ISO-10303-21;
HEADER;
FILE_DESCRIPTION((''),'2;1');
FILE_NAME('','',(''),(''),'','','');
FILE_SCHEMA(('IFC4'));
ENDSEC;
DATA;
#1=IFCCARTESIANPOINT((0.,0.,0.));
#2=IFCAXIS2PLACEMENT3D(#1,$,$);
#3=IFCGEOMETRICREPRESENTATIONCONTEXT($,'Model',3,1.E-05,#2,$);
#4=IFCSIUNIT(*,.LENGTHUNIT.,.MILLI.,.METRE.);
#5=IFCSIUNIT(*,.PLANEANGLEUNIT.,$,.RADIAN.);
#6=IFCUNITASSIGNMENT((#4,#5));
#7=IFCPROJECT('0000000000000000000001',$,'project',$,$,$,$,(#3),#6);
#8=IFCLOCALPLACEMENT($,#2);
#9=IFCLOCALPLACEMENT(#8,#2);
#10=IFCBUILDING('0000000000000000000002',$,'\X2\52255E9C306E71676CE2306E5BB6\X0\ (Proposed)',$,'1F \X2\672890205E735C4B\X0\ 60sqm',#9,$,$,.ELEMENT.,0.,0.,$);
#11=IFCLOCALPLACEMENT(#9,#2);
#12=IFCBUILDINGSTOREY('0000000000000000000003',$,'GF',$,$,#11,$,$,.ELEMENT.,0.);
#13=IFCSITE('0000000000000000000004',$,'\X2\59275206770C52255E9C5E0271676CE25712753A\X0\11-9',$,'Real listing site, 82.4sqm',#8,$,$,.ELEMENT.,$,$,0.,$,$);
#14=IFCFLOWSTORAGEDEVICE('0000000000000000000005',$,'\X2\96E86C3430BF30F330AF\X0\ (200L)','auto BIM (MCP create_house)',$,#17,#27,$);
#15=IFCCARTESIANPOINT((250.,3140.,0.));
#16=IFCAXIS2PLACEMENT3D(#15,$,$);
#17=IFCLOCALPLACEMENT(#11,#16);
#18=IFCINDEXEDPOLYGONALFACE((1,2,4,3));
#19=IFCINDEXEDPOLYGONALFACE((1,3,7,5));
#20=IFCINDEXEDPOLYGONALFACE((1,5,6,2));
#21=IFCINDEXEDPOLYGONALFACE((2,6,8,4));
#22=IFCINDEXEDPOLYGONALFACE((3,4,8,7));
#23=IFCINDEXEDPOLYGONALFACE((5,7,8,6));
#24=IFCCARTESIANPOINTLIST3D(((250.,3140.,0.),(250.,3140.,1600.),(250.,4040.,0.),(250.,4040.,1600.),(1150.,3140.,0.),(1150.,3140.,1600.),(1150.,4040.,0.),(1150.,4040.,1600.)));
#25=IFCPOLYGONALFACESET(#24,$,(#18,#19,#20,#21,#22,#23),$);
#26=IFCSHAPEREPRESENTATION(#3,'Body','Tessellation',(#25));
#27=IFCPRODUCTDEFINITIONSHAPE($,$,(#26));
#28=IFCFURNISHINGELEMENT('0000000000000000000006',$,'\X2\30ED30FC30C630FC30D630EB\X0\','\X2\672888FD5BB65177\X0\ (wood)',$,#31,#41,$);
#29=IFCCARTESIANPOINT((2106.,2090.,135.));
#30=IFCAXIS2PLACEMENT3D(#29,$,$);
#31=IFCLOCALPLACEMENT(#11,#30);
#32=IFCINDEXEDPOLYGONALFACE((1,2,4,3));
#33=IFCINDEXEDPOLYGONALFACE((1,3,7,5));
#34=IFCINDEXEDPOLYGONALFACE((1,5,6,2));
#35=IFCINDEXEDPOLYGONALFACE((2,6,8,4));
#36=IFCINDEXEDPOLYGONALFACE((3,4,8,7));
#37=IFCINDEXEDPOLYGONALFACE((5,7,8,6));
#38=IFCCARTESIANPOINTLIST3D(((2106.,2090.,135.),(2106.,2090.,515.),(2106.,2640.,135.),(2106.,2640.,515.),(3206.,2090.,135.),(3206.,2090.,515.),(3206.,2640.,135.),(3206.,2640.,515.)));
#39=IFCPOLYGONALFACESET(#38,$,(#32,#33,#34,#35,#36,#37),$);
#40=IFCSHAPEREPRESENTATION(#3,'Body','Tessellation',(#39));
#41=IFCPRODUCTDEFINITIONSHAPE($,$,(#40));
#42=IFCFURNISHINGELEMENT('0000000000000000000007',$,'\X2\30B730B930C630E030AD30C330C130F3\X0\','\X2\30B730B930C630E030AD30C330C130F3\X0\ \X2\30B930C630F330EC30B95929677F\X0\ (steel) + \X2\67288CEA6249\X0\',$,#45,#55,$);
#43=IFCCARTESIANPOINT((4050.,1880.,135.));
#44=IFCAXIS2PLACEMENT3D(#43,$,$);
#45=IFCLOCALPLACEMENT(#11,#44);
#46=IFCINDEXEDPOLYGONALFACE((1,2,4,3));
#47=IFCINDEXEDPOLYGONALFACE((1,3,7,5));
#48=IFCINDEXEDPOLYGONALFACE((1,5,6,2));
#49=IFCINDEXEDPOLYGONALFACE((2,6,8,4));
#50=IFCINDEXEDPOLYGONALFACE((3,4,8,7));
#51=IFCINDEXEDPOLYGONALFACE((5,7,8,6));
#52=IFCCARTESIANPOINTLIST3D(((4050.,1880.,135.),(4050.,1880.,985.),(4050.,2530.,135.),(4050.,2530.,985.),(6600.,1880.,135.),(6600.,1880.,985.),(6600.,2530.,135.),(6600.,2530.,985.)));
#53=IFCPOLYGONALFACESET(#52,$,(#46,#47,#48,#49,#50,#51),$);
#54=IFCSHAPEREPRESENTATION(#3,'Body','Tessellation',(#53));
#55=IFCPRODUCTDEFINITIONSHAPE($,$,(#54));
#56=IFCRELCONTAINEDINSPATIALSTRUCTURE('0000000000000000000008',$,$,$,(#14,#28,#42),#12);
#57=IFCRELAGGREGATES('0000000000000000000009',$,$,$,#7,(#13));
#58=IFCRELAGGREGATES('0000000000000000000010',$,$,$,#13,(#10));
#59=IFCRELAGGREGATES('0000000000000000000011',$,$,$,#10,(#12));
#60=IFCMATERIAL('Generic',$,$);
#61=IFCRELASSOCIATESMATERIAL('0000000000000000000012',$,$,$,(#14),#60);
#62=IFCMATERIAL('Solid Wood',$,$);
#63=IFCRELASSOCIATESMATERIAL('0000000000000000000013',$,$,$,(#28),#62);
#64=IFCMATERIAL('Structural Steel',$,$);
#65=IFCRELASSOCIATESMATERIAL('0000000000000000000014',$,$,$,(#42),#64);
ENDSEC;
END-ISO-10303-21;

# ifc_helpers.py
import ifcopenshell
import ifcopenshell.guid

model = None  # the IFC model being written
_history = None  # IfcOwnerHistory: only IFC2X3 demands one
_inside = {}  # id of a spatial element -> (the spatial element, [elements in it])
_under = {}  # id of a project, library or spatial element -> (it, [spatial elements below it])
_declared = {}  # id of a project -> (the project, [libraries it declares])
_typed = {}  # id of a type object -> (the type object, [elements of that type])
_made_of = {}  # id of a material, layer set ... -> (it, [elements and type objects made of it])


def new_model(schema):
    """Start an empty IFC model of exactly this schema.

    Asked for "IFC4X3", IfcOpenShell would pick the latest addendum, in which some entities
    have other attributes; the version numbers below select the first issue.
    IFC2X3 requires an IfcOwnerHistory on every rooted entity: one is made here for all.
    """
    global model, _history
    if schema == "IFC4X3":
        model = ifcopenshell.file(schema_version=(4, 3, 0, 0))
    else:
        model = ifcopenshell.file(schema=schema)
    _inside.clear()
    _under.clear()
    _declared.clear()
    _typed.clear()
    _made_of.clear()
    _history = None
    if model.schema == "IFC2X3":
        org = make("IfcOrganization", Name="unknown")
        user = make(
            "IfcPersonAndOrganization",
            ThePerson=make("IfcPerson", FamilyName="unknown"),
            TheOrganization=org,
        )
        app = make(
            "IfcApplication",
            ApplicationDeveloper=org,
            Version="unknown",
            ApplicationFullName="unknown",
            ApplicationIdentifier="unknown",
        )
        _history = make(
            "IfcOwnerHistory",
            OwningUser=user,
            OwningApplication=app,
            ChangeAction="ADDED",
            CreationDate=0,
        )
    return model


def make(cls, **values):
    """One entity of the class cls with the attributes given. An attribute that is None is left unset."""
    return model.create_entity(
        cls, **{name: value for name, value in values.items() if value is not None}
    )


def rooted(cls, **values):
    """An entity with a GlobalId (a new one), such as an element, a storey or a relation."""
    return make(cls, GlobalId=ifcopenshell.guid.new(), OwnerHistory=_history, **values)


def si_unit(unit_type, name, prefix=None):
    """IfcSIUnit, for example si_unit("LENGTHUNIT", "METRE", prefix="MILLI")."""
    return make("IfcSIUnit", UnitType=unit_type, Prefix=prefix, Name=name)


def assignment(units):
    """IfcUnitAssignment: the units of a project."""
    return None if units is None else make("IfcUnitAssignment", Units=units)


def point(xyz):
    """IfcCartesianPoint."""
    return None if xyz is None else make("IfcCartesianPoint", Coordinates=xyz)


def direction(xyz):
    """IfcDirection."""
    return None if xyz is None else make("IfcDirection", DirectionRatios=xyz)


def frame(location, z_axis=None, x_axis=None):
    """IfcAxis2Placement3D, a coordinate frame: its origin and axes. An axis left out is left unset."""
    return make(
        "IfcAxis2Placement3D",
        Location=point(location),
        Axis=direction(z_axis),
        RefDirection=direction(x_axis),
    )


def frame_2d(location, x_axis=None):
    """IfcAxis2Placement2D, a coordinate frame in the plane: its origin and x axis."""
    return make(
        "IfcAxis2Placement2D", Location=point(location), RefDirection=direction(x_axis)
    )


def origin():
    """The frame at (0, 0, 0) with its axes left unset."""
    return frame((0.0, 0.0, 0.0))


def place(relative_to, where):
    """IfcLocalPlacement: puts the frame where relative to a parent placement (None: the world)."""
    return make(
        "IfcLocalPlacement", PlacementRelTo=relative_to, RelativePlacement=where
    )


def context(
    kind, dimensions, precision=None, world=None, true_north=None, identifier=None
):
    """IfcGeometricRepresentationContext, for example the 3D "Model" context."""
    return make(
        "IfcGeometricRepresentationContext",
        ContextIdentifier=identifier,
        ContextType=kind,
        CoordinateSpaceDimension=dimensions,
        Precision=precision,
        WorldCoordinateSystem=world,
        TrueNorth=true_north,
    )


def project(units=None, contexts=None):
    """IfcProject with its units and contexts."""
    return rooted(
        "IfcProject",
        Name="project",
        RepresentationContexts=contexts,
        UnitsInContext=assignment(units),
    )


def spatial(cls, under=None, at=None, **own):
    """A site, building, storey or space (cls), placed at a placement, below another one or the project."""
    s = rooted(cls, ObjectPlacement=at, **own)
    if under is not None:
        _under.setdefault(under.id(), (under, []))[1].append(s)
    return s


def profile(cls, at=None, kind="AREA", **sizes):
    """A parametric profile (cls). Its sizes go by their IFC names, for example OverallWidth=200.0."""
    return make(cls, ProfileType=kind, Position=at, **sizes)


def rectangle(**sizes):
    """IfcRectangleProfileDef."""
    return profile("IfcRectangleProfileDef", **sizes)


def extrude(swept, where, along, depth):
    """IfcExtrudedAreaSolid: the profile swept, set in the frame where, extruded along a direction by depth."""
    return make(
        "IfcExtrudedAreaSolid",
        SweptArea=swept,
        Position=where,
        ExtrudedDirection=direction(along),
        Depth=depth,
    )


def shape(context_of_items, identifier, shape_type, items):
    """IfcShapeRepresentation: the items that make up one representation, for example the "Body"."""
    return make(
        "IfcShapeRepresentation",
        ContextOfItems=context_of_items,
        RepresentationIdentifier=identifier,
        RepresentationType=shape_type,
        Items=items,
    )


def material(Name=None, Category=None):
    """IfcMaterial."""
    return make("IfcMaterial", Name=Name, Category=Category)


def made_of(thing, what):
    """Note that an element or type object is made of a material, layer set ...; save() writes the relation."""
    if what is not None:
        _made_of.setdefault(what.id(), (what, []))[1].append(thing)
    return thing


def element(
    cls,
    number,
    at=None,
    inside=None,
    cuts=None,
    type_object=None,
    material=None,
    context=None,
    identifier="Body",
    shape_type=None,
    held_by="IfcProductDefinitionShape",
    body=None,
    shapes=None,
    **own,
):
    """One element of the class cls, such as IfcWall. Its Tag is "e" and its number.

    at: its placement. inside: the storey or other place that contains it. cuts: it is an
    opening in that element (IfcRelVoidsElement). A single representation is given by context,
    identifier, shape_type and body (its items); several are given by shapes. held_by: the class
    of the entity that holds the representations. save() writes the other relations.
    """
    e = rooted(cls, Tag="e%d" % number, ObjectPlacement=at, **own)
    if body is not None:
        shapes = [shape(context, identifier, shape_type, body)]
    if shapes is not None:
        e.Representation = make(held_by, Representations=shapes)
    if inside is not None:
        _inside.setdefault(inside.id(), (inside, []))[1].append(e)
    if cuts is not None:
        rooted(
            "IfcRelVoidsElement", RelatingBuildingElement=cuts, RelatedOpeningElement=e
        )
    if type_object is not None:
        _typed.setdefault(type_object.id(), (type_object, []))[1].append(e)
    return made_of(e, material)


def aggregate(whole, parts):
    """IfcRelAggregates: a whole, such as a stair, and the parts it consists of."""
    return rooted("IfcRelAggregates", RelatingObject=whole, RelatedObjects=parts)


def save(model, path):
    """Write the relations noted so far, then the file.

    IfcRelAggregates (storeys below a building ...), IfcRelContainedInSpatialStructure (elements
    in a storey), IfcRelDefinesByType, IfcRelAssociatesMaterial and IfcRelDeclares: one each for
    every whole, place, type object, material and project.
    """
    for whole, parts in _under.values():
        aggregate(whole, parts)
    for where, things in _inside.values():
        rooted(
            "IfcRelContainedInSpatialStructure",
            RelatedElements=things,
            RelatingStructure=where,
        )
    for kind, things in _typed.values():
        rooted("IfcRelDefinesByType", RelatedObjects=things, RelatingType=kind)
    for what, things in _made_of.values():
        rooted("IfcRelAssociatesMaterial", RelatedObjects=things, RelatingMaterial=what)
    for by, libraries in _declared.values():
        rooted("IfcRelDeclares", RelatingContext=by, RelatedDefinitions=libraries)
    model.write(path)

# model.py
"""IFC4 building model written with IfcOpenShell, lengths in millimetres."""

from ifc_helpers import new_model, si_unit, frame, frame_2d, origin, place, context, project, spatial, rectangle, extrude, material, element, save


model = new_model("IFC4")

# Units and contexts
model_context = context("Model", 3, precision=1e-05, world=origin())
ifc_project = project(units=[si_unit("LENGTHUNIT", "METRE", prefix="MILLI"), si_unit("PLANEANGLEUNIT", "RADIAN")], contexts=[model_context])

# Site, building, storey
site_placement = place(None, origin())
site = spatial("IfcSite", under=ifc_project, at=site_placement, Name="大分県別府市照波園町11-9", ObjectType="Real listing site, 82.4sqm", CompositionType="ELEMENT", RefElevation=0.0)
building_placement = place(site_placement, origin())
building = spatial("IfcBuilding", under=site, at=building_placement, Name="別府の照波の家 (Proposed)", ObjectType="1F 木造平屋 60sqm", CompositionType="ELEMENT", ElevationOfRefHeight=0.0, ElevationOfTerrain=0.0)
storey_placement = place(building_placement, origin())
storey = spatial("IfcBuildingStorey", under=building, at=storey_placement, Name="GF", CompositionType="ELEMENT", Elevation=0.0)

# Shared definitions
ifc_material_1 = material(Name="Solid Wood")

# Shared definitions
ifc_material_2 = material(Name="Generic")

# Flow storage device
flow_storage_device_placement = place(storey_placement, frame((250.0, 3140.0, 0.0)))
element("IfcFlowStorageDevice", 1, at=flow_storage_device_placement, inside=storey, material=ifc_material_2, Name="雨水タンク (200L)", Description="auto BIM (MCP create_house)", context=model_context, shape_type="SweptSolid", body=[
    extrude(rectangle(XDim=900.0, YDim=900.0, at=frame_2d((450.0, 450.0))), frame((250.0, 3140.0, 0.0)), (0.0, 0.0, 1.0), 1600.0),
])

# Furnishing elements
furnishing_1_placement = place(storey_placement, frame((2106.0, 2090.0, 135.0)))
element("IfcFurnishingElement", 2, at=furnishing_1_placement, inside=storey, material=ifc_material_1, Name="ローテーブル", Description="木製家具 (wood)", context=model_context, shape_type="SweptSolid", body=[
    extrude(rectangle(XDim=1100.0, YDim=550.0, at=frame_2d((550.0, 275.0))), frame((2106.0, 2090.0, 135.0)), (0.0, 0.0, 1.0), 380.0),
])
ifc_material_3 = material(Name="Structural Steel")
furnishing_2_placement = place(storey_placement, frame((4050.0, 1880.0, 135.0)))
element("IfcFurnishingElement", 3, at=furnishing_2_placement, inside=storey, material=ifc_material_3, Name="システムキッチン", Description="システムキッチン ステンレス天板 (steel) + 木質扉", context=model_context, shape_type="SweptSolid", body=[
    extrude(rectangle(XDim=2550.0, YDim=650.0, at=frame_2d((1275.0, 325.0))), frame((4050.0, 1880.0, 135.0)), (0.0, 0.0, 1.0), 850.0),
])

save(model, "model.ifc")
